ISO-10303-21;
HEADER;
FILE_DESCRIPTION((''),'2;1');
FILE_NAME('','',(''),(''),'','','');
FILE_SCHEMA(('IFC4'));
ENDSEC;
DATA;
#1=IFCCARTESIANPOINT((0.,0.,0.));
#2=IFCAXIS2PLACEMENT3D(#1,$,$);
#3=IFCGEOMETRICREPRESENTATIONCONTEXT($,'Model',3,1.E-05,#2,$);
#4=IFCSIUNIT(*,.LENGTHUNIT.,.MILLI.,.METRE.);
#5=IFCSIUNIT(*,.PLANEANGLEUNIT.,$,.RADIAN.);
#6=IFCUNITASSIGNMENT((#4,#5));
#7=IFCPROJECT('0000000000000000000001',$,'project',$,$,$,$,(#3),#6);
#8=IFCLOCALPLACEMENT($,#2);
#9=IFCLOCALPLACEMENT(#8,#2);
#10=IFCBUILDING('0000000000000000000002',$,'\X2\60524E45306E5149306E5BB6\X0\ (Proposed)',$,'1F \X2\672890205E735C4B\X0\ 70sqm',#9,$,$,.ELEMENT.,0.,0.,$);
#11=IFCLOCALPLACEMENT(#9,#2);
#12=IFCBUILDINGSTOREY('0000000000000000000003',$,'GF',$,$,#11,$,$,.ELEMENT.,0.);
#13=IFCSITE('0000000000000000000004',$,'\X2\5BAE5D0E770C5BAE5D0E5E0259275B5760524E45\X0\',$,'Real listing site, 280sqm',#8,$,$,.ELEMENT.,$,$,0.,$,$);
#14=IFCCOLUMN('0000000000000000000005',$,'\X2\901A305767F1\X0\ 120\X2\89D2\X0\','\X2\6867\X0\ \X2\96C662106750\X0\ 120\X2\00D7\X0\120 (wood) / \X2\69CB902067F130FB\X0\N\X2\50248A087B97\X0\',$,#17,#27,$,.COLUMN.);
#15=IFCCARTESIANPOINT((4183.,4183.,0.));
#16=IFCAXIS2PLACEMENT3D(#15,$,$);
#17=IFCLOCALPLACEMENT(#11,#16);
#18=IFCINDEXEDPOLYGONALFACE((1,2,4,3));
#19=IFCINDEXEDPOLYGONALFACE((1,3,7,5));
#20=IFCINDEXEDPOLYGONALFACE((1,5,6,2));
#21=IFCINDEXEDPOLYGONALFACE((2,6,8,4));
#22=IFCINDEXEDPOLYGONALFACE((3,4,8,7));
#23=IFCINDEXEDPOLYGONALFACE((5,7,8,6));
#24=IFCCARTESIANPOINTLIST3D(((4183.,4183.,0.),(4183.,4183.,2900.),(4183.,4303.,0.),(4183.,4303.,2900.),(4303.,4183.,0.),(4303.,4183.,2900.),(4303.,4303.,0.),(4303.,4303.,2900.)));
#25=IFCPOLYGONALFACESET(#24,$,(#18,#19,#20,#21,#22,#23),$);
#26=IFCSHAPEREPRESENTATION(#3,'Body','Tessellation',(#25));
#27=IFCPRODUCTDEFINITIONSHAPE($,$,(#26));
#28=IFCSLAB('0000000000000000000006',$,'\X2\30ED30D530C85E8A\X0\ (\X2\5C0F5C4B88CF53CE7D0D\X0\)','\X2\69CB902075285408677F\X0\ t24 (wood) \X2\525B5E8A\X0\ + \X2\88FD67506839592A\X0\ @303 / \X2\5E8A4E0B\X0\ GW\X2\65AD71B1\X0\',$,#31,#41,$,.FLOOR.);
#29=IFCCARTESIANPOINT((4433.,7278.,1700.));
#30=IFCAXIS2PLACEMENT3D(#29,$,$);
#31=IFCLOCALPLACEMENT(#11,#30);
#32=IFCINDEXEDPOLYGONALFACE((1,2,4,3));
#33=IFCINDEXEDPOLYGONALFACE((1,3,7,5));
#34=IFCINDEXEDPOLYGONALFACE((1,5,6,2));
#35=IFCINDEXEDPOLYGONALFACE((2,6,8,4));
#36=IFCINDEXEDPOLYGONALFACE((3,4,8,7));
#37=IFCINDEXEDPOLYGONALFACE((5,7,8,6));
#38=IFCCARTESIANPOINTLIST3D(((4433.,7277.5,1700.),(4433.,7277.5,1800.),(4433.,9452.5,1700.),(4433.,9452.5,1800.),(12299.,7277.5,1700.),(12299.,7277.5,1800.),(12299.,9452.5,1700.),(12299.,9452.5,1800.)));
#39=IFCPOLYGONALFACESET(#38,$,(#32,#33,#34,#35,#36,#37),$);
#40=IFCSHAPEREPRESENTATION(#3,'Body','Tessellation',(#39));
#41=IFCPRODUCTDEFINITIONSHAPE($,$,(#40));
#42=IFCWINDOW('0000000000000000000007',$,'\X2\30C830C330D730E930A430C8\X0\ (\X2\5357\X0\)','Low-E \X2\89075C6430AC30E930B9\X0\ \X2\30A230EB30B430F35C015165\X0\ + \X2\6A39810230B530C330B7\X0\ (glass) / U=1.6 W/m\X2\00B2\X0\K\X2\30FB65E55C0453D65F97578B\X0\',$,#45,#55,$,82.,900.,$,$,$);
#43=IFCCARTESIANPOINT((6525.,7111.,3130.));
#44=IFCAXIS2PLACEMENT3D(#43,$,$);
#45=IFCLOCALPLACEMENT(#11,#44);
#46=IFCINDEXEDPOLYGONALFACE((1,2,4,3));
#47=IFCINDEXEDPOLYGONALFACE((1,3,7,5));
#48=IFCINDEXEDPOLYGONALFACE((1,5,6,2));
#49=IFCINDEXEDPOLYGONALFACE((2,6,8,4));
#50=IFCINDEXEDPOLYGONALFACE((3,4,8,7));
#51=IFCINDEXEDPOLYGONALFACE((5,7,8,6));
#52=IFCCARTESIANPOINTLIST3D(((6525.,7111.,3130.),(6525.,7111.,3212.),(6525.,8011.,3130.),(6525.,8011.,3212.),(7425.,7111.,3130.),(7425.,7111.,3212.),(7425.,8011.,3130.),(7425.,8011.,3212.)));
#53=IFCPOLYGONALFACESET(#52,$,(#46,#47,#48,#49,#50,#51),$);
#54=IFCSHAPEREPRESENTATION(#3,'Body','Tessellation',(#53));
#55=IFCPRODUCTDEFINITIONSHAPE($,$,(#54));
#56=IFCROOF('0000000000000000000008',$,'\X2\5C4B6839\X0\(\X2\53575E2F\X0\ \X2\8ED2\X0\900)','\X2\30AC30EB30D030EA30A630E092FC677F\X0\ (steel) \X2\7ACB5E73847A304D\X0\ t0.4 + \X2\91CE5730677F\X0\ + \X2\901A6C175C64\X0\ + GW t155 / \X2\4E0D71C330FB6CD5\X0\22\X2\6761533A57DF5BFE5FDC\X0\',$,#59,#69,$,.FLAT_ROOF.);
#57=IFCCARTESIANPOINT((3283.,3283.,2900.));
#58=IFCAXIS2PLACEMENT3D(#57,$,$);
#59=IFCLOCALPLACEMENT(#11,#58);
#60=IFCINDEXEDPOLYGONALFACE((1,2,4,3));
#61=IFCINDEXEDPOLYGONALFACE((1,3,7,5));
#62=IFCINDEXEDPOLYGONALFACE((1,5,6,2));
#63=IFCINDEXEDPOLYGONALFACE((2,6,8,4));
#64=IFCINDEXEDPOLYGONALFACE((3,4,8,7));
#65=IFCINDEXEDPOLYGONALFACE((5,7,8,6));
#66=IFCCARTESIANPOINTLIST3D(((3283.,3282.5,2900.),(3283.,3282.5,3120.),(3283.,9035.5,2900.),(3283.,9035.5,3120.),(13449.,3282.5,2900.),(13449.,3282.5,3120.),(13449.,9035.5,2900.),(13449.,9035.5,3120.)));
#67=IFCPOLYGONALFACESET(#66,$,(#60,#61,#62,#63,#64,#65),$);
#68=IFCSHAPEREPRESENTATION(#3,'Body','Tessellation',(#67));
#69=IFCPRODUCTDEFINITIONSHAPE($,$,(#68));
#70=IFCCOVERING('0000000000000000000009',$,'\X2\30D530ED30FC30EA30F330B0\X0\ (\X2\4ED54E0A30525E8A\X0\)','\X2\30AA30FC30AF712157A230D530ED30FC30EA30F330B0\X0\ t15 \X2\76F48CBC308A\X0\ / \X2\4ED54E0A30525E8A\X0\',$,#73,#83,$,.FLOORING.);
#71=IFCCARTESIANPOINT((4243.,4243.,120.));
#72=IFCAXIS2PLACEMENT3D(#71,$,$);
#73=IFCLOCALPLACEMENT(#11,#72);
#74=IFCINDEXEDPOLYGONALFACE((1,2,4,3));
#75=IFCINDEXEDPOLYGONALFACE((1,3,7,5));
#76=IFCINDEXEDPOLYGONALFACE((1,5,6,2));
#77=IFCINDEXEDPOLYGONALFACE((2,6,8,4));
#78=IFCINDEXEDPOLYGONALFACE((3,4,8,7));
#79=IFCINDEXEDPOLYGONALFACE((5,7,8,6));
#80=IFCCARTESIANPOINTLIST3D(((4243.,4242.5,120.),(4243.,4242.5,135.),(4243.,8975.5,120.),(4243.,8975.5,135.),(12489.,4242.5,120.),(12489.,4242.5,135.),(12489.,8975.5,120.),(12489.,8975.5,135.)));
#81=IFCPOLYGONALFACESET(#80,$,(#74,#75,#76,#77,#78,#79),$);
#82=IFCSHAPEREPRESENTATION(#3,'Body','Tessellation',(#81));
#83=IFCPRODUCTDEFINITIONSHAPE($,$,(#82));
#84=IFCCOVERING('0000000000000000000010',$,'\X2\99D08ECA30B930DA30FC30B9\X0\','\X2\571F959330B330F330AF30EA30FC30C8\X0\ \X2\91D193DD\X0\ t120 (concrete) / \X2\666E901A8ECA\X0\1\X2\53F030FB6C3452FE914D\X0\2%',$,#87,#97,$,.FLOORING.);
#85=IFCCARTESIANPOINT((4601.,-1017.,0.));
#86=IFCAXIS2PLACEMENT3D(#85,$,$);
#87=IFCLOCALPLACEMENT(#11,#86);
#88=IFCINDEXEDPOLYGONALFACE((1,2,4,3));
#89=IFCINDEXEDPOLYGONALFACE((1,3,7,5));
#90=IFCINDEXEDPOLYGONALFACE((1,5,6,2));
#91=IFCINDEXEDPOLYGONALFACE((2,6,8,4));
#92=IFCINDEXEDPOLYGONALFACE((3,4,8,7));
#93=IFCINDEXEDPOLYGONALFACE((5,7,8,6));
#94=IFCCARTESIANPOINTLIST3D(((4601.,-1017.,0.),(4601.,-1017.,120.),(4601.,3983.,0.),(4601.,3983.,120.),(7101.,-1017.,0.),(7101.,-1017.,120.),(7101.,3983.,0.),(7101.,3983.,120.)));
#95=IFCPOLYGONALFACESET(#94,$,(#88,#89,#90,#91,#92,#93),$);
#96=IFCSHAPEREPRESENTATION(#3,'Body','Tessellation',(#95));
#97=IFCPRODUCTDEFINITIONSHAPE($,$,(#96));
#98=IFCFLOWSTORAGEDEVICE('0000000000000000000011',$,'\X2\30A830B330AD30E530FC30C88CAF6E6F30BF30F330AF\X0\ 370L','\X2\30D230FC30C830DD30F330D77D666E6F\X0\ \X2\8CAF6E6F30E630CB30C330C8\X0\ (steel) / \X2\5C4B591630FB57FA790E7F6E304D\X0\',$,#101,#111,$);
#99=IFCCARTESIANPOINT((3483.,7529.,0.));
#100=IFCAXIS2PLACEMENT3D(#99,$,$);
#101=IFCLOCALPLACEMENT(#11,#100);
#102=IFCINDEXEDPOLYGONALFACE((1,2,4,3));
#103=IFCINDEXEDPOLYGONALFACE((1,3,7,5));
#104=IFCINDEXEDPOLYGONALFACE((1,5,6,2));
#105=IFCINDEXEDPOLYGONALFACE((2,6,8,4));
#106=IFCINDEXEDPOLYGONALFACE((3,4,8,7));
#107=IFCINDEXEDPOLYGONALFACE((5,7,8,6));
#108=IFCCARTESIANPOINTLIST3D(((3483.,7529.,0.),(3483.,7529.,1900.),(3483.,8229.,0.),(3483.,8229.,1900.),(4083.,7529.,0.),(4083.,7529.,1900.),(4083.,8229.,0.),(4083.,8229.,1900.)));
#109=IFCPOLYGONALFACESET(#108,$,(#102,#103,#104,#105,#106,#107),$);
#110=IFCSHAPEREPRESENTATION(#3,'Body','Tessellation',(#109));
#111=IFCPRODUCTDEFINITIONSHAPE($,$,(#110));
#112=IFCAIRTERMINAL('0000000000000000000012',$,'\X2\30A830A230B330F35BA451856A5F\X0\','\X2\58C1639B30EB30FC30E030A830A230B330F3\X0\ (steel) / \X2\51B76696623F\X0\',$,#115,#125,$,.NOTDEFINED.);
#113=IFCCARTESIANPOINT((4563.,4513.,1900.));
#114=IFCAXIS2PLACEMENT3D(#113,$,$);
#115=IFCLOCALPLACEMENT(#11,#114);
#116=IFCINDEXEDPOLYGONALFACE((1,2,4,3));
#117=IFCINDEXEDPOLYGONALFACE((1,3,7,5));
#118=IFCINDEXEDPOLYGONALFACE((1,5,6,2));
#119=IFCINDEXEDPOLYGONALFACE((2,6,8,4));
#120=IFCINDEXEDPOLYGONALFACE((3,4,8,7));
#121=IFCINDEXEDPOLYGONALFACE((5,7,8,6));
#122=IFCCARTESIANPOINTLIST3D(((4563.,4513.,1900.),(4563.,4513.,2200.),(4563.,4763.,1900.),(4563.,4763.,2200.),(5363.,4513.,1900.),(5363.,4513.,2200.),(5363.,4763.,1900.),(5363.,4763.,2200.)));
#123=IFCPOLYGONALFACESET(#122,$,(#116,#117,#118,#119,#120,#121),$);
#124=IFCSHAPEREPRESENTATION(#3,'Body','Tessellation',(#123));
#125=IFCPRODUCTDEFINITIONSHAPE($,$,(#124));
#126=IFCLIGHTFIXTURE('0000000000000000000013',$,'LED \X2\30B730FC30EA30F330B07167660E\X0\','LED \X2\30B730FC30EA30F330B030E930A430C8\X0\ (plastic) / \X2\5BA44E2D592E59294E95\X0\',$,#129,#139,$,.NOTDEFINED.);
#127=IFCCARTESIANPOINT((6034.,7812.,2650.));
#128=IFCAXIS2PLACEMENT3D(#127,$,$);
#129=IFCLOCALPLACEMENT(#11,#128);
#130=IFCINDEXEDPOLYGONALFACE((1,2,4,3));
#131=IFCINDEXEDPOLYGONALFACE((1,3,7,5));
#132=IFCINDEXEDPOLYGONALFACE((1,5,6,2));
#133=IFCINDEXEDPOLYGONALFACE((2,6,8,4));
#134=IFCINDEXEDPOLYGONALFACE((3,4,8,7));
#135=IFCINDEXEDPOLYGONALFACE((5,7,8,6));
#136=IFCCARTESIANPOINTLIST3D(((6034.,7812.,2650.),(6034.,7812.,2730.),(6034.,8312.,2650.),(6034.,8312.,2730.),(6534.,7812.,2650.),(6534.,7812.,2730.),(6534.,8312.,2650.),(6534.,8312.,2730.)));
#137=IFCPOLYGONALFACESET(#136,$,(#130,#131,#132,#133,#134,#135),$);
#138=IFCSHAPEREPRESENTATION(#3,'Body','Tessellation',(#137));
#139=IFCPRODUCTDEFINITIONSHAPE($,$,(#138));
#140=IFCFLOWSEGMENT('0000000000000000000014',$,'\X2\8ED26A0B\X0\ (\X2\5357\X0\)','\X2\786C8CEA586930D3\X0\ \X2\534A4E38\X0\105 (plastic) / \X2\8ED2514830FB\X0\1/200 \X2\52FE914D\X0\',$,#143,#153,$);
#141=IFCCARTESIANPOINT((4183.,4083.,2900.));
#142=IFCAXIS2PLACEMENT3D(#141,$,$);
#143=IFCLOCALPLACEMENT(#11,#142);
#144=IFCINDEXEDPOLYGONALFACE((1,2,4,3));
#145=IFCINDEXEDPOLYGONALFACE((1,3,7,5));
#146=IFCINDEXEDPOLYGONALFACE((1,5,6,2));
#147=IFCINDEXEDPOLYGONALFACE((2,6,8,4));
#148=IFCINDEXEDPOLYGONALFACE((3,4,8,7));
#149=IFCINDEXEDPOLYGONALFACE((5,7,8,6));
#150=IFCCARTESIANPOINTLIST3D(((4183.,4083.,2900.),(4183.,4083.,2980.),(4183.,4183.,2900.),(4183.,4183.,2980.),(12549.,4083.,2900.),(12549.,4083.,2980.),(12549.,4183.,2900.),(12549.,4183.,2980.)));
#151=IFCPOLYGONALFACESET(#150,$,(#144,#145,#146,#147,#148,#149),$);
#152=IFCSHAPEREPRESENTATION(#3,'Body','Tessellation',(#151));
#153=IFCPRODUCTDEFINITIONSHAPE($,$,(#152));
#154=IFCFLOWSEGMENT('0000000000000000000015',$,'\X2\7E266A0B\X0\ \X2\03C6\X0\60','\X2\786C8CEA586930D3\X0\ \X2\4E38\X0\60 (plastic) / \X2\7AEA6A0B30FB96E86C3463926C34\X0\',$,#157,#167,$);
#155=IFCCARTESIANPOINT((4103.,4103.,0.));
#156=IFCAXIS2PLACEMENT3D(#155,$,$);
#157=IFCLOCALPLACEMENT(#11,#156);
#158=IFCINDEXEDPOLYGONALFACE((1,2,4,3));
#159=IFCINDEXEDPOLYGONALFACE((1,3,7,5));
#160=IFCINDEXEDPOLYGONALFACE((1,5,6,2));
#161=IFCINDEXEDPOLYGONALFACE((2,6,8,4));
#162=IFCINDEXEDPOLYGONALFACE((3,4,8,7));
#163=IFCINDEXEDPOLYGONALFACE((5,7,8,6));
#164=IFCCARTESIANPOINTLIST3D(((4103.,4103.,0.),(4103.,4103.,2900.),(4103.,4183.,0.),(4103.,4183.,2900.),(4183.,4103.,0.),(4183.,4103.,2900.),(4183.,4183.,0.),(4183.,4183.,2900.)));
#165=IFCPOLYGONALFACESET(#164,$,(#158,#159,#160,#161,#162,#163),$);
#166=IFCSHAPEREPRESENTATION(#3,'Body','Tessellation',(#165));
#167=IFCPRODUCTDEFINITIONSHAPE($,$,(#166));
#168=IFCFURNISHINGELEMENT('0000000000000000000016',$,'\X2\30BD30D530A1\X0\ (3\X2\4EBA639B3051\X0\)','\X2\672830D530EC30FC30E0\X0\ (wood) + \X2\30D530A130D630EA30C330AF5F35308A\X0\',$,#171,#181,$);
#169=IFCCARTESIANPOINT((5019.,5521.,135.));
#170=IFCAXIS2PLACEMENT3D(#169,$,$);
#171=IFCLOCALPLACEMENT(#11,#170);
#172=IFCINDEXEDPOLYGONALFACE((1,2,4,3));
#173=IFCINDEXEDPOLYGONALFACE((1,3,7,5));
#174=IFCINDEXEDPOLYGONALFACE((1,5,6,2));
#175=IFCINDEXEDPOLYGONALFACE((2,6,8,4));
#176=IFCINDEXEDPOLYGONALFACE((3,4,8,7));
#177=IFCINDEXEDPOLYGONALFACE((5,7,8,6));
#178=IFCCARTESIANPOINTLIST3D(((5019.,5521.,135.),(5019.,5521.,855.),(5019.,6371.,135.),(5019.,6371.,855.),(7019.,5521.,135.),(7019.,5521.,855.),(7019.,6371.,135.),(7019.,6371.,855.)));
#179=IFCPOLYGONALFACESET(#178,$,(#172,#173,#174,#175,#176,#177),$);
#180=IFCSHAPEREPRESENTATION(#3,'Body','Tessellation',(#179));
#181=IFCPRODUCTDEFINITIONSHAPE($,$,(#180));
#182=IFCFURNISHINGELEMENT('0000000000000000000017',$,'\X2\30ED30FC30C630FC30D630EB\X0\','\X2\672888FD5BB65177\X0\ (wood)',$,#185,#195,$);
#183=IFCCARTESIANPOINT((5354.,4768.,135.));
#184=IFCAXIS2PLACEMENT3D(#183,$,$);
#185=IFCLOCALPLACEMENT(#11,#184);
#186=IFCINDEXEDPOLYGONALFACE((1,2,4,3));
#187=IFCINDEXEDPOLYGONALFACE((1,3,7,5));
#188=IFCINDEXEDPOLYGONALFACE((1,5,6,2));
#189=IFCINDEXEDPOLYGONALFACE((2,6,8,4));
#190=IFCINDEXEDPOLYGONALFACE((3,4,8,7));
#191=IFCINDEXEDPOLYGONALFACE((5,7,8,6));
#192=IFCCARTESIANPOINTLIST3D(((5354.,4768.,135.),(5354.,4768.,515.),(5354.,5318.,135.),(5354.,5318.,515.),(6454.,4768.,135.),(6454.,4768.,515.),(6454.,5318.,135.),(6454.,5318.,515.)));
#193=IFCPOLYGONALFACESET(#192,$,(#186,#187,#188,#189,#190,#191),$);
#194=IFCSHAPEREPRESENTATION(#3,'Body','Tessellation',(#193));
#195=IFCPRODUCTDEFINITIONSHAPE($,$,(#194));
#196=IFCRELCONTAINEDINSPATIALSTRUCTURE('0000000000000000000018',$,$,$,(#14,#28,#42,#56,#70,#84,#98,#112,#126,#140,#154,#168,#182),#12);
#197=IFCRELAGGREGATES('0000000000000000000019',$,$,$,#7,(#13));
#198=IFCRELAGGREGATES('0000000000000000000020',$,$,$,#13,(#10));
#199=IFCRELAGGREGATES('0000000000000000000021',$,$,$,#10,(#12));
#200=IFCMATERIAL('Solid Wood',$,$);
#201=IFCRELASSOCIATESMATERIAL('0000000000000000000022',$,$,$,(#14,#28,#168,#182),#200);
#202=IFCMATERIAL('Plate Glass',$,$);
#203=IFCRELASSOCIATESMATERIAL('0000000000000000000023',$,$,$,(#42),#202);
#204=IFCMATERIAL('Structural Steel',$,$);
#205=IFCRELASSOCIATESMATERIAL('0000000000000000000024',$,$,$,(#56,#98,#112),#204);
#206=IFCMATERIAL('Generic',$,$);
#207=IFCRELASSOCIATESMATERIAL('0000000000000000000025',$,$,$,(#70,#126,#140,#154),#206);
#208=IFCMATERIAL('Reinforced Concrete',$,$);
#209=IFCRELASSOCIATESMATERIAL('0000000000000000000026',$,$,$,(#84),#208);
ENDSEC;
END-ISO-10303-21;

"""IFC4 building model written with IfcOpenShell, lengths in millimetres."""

from ifc_helpers import new_model, si_unit, frame, frame_2d, origin, place, context, project, spatial, rectangle, extrude, material, element, save


model = new_model("IFC4")

# Units and contexts
model_context = context("Model", 3, precision=1e-05, world=origin())
ifc_project = project(units=[si_unit("LENGTHUNIT", "METRE", prefix="MILLI"), si_unit("PLANEANGLEUNIT", "RADIAN")], contexts=[model_context])

# Site, building, storey
site_placement = place(None, origin())
site = spatial("IfcSite", under=ifc_project, at=site_placement, Name="宮崎県宮崎市大字恒久", ObjectType="Real listing site, 280sqm", CompositionType="ELEMENT", RefElevation=0.0)
building_placement = place(site_placement, origin())
building = spatial("IfcBuilding", under=site, at=building_placement, Name="恒久の光の家 (Proposed)", ObjectType="1F 木造平屋 70sqm", CompositionType="ELEMENT", ElevationOfRefHeight=0.0, ElevationOfTerrain=0.0)
storey_placement = place(building_placement, origin())
storey = spatial("IfcBuildingStorey", under=building, at=storey_placement, Name="GF", CompositionType="ELEMENT", Elevation=0.0)

# Column
ifc_material_1 = material(Name="Solid Wood")
column_1_placement = place(storey_placement, frame((4183.0, 4183.0, 0.0)))
element("IfcColumn", 1, at=column_1_placement, inside=storey, material=ifc_material_1, Name="通し柱 120角", Description="桧 集成材 120×120 (wood) / 構造柱・N値計算", PredefinedType="COLUMN", context=model_context, shape_type="SweptSolid", body=[
    extrude(rectangle(XDim=120.0, YDim=120.0, at=frame_2d((60.0, 60.0))), frame((4183.0, 4183.0, 0.0)), (0.0, 0.0, 1.0), 2900.0),
])

# Slab
ifc_material_2 = material(Name="Reinforced Concrete")
slab_1_placement = place(storey_placement, frame((4433.0, 7278.0, 1700.0)))
element("IfcSlab", 2, at=slab_1_placement, inside=storey, material=ifc_material_1, Name="ロフト床 (小屋裏収納)", Description="構造用合板 t24 (wood) 剛床 + 製材根太 @303 / 床下 GW断熱", PredefinedType="FLOOR", context=model_context, shape_type="SweptSolid", body=[
    extrude(rectangle(XDim=7866.0, YDim=2175.0, at=frame_2d((3933.0, 1087.0))), frame((4433.0, 7278.0, 1700.0)), (0.0, 0.0, 1.0), 100.0),
])

# Shared definitions
ifc_material_3 = material(Name="Plate Glass")

# Window
window_1_placement = place(storey_placement, frame((6525.0, 7111.0, 3130.0)))
element("IfcWindow", 3, at=window_1_placement, inside=storey, material=ifc_material_3, Name="トップライト (南)", Description="Low-E 複層ガラス アルゴン封入 + 樹脂サッシ (glass) / U=1.6 W/m²K・日射取得型", OverallHeight=82.0, OverallWidth=900.0, context=model_context, shape_type="SweptSolid", body=[
    extrude(rectangle(XDim=900.0, YDim=900.0, at=frame_2d((450.0, 450.0))), frame((6525.0, 7111.0, 3130.0)), (0.0, 0.0, 1.0), 82.0),
])

# Roof
ifc_material_4 = material(Name="Structural Steel")
roof_placement = place(storey_placement, frame((3283.0, 3283.0, 2900.0)))
element("IfcRoof", 4, at=roof_placement, inside=storey, material=ifc_material_4, Name="屋根(南帯 軒900)", Description="ガルバリウム鋼板 (steel) 立平葺き t0.4 + 野地板 + 通気層 + GW t155 / 不燃・法22条区域対応", PredefinedType="FLAT_ROOF", context=model_context, shape_type="SweptSolid", body=[
    extrude(rectangle(XDim=10166.0, YDim=5753.0, at=frame_2d((5083.0, 2876.0))), frame((3283.0, 3283.0, 2900.0)), (0.0, 0.0, 1.0), 220.0),
])

# Coverings
ifc_material_5 = material(Name="Generic")
covering_1_placement = place(storey_placement, frame((4243.0, 4243.0, 120.0)))
element("IfcCovering", 5, at=covering_1_placement, inside=storey, material=ifc_material_5, Name="フローリング (仕上げ床)", Description="オーク無垢フローリング t15 直貼り / 仕上げ床", PredefinedType="FLOORING", context=model_context, shape_type="SweptSolid", body=[
    extrude(rectangle(XDim=8246.0, YDim=4733.0, at=frame_2d((4123.0, 2366.0))), frame((4243.0, 4243.0, 120.0)), (0.0, 0.0, 1.0), 15.0),
])
covering_2_placement = place(storey_placement, frame((4601.0, -1017.0, 0.0)))
element("IfcCovering", 6, at=covering_2_placement, inside=storey, material=ifc_material_2, Name="駐車スペース", Description="土間コンクリート 金鏝 t120 (concrete) / 普通車1台・水勾配2%", PredefinedType="FLOORING", context=model_context, shape_type="SweptSolid", body=[
    extrude(rectangle(XDim=2500.0, YDim=5000.0, at=frame_2d((1250.0, 2500.0))), frame((4601.0, -1017.0, 0.0)), (0.0, 0.0, 1.0), 120.0),
])

# Flow storage device
flow_storage_device_placement = place(storey_placement, frame((3483.0, 7529.0, 0.0)))
element("IfcFlowStorageDevice", 7, at=flow_storage_device_placement, inside=storey, material=ifc_material_4, Name="エコキュート貯湯タンク 370L", Description="ヒートポンプ給湯 貯湯ユニット (steel) / 屋外・基礎置き", context=model_context, shape_type="SweptSolid", body=[
    extrude(rectangle(XDim=600.0, YDim=700.0, at=frame_2d((300.0, 350.0))), frame((3483.0, 7529.0, 0.0)), (0.0, 0.0, 1.0), 1900.0),
])

# Air terminal
air_terminal_placement = place(storey_placement, frame((4563.0, 4513.0, 1900.0)))
element("IfcAirTerminal", 8, at=air_terminal_placement, inside=storey, material=ifc_material_4, Name="エアコン室内機", Description="壁掛ルームエアコン (steel) / 冷暖房", PredefinedType="NOTDEFINED", context=model_context, shape_type="SweptSolid", body=[
    extrude(rectangle(XDim=800.0, YDim=250.0, at=frame_2d((400.0, 125.0))), frame((4563.0, 4513.0, 1900.0)), (0.0, 0.0, 1.0), 300.0),
])

# Light fixture
light_fixture_placement = place(storey_placement, frame((6034.0, 7812.0, 2650.0)))
element("IfcLightFixture", 9, at=light_fixture_placement, inside=storey, material=ifc_material_5, Name="LED シーリング照明", Description="LED シーリングライト (plastic) / 室中央天井", PredefinedType="NOTDEFINED", context=model_context, shape_type="SweptSolid", body=[
    extrude(rectangle(XDim=500.0, YDim=500.0, at=frame_2d((250.0, 250.0))), frame((6034.0, 7812.0, 2650.0)), (0.0, 0.0, 1.0), 80.0),
])

# Flow segments
flow_segment_1_placement = place(storey_placement, frame((4183.0, 4083.0, 2900.0)))
element("IfcFlowSegment", 10, at=flow_segment_1_placement, inside=storey, material=ifc_material_5, Name="軒樋 (南)", Description="硬質塩ビ 半丸105 (plastic) / 軒先・1/200 勾配", context=model_context, shape_type="SweptSolid", body=[
    extrude(rectangle(XDim=8366.0, YDim=100.0, at=frame_2d((4183.0, 50.0))), frame((4183.0, 4083.0, 2900.0)), (0.0, 0.0, 1.0), 80.0),
])
flow_segment_2_placement = place(storey_placement, frame((4103.0, 4103.0, 0.0)))
element("IfcFlowSegment", 11, at=flow_segment_2_placement, inside=storey, material=ifc_material_5, Name="縦樋 φ60", Description="硬質塩ビ 丸60 (plastic) / 竪樋・雨水排水", context=model_context, shape_type="SweptSolid", body=[
    extrude(rectangle(XDim=80.0, YDim=80.0, at=frame_2d((40.0, 40.0))), frame((4103.0, 4103.0, 0.0)), (0.0, 0.0, 1.0), 2900.0),
])

# Furnishing elements
furnishing_1_placement = place(storey_placement, frame((5019.0, 5521.0, 135.0)))
element("IfcFurnishingElement", 12, at=furnishing_1_placement, inside=storey, material=ifc_material_1, Name="ソファ (3人掛け)", Description="木フレーム (wood) + ファブリック張り", context=model_context, shape_type="SweptSolid", body=[
    extrude(rectangle(XDim=2000.0, YDim=850.0, at=frame_2d((1000.0, 425.0))), frame((5019.0, 5521.0, 135.0)), (0.0, 0.0, 1.0), 720.0),
])
furnishing_2_placement = place(storey_placement, frame((5354.0, 4768.0, 135.0)))
element("IfcFurnishingElement", 13, at=furnishing_2_placement, inside=storey, material=ifc_material_1, Name="ローテーブル", Description="木製家具 (wood)", context=model_context, shape_type="SweptSolid", body=[
    extrude(rectangle(XDim=1100.0, YDim=550.0, at=frame_2d((550.0, 275.0))), frame((5354.0, 4768.0, 135.0)), (0.0, 0.0, 1.0), 380.0),
])

save(model, "model.ifc")
